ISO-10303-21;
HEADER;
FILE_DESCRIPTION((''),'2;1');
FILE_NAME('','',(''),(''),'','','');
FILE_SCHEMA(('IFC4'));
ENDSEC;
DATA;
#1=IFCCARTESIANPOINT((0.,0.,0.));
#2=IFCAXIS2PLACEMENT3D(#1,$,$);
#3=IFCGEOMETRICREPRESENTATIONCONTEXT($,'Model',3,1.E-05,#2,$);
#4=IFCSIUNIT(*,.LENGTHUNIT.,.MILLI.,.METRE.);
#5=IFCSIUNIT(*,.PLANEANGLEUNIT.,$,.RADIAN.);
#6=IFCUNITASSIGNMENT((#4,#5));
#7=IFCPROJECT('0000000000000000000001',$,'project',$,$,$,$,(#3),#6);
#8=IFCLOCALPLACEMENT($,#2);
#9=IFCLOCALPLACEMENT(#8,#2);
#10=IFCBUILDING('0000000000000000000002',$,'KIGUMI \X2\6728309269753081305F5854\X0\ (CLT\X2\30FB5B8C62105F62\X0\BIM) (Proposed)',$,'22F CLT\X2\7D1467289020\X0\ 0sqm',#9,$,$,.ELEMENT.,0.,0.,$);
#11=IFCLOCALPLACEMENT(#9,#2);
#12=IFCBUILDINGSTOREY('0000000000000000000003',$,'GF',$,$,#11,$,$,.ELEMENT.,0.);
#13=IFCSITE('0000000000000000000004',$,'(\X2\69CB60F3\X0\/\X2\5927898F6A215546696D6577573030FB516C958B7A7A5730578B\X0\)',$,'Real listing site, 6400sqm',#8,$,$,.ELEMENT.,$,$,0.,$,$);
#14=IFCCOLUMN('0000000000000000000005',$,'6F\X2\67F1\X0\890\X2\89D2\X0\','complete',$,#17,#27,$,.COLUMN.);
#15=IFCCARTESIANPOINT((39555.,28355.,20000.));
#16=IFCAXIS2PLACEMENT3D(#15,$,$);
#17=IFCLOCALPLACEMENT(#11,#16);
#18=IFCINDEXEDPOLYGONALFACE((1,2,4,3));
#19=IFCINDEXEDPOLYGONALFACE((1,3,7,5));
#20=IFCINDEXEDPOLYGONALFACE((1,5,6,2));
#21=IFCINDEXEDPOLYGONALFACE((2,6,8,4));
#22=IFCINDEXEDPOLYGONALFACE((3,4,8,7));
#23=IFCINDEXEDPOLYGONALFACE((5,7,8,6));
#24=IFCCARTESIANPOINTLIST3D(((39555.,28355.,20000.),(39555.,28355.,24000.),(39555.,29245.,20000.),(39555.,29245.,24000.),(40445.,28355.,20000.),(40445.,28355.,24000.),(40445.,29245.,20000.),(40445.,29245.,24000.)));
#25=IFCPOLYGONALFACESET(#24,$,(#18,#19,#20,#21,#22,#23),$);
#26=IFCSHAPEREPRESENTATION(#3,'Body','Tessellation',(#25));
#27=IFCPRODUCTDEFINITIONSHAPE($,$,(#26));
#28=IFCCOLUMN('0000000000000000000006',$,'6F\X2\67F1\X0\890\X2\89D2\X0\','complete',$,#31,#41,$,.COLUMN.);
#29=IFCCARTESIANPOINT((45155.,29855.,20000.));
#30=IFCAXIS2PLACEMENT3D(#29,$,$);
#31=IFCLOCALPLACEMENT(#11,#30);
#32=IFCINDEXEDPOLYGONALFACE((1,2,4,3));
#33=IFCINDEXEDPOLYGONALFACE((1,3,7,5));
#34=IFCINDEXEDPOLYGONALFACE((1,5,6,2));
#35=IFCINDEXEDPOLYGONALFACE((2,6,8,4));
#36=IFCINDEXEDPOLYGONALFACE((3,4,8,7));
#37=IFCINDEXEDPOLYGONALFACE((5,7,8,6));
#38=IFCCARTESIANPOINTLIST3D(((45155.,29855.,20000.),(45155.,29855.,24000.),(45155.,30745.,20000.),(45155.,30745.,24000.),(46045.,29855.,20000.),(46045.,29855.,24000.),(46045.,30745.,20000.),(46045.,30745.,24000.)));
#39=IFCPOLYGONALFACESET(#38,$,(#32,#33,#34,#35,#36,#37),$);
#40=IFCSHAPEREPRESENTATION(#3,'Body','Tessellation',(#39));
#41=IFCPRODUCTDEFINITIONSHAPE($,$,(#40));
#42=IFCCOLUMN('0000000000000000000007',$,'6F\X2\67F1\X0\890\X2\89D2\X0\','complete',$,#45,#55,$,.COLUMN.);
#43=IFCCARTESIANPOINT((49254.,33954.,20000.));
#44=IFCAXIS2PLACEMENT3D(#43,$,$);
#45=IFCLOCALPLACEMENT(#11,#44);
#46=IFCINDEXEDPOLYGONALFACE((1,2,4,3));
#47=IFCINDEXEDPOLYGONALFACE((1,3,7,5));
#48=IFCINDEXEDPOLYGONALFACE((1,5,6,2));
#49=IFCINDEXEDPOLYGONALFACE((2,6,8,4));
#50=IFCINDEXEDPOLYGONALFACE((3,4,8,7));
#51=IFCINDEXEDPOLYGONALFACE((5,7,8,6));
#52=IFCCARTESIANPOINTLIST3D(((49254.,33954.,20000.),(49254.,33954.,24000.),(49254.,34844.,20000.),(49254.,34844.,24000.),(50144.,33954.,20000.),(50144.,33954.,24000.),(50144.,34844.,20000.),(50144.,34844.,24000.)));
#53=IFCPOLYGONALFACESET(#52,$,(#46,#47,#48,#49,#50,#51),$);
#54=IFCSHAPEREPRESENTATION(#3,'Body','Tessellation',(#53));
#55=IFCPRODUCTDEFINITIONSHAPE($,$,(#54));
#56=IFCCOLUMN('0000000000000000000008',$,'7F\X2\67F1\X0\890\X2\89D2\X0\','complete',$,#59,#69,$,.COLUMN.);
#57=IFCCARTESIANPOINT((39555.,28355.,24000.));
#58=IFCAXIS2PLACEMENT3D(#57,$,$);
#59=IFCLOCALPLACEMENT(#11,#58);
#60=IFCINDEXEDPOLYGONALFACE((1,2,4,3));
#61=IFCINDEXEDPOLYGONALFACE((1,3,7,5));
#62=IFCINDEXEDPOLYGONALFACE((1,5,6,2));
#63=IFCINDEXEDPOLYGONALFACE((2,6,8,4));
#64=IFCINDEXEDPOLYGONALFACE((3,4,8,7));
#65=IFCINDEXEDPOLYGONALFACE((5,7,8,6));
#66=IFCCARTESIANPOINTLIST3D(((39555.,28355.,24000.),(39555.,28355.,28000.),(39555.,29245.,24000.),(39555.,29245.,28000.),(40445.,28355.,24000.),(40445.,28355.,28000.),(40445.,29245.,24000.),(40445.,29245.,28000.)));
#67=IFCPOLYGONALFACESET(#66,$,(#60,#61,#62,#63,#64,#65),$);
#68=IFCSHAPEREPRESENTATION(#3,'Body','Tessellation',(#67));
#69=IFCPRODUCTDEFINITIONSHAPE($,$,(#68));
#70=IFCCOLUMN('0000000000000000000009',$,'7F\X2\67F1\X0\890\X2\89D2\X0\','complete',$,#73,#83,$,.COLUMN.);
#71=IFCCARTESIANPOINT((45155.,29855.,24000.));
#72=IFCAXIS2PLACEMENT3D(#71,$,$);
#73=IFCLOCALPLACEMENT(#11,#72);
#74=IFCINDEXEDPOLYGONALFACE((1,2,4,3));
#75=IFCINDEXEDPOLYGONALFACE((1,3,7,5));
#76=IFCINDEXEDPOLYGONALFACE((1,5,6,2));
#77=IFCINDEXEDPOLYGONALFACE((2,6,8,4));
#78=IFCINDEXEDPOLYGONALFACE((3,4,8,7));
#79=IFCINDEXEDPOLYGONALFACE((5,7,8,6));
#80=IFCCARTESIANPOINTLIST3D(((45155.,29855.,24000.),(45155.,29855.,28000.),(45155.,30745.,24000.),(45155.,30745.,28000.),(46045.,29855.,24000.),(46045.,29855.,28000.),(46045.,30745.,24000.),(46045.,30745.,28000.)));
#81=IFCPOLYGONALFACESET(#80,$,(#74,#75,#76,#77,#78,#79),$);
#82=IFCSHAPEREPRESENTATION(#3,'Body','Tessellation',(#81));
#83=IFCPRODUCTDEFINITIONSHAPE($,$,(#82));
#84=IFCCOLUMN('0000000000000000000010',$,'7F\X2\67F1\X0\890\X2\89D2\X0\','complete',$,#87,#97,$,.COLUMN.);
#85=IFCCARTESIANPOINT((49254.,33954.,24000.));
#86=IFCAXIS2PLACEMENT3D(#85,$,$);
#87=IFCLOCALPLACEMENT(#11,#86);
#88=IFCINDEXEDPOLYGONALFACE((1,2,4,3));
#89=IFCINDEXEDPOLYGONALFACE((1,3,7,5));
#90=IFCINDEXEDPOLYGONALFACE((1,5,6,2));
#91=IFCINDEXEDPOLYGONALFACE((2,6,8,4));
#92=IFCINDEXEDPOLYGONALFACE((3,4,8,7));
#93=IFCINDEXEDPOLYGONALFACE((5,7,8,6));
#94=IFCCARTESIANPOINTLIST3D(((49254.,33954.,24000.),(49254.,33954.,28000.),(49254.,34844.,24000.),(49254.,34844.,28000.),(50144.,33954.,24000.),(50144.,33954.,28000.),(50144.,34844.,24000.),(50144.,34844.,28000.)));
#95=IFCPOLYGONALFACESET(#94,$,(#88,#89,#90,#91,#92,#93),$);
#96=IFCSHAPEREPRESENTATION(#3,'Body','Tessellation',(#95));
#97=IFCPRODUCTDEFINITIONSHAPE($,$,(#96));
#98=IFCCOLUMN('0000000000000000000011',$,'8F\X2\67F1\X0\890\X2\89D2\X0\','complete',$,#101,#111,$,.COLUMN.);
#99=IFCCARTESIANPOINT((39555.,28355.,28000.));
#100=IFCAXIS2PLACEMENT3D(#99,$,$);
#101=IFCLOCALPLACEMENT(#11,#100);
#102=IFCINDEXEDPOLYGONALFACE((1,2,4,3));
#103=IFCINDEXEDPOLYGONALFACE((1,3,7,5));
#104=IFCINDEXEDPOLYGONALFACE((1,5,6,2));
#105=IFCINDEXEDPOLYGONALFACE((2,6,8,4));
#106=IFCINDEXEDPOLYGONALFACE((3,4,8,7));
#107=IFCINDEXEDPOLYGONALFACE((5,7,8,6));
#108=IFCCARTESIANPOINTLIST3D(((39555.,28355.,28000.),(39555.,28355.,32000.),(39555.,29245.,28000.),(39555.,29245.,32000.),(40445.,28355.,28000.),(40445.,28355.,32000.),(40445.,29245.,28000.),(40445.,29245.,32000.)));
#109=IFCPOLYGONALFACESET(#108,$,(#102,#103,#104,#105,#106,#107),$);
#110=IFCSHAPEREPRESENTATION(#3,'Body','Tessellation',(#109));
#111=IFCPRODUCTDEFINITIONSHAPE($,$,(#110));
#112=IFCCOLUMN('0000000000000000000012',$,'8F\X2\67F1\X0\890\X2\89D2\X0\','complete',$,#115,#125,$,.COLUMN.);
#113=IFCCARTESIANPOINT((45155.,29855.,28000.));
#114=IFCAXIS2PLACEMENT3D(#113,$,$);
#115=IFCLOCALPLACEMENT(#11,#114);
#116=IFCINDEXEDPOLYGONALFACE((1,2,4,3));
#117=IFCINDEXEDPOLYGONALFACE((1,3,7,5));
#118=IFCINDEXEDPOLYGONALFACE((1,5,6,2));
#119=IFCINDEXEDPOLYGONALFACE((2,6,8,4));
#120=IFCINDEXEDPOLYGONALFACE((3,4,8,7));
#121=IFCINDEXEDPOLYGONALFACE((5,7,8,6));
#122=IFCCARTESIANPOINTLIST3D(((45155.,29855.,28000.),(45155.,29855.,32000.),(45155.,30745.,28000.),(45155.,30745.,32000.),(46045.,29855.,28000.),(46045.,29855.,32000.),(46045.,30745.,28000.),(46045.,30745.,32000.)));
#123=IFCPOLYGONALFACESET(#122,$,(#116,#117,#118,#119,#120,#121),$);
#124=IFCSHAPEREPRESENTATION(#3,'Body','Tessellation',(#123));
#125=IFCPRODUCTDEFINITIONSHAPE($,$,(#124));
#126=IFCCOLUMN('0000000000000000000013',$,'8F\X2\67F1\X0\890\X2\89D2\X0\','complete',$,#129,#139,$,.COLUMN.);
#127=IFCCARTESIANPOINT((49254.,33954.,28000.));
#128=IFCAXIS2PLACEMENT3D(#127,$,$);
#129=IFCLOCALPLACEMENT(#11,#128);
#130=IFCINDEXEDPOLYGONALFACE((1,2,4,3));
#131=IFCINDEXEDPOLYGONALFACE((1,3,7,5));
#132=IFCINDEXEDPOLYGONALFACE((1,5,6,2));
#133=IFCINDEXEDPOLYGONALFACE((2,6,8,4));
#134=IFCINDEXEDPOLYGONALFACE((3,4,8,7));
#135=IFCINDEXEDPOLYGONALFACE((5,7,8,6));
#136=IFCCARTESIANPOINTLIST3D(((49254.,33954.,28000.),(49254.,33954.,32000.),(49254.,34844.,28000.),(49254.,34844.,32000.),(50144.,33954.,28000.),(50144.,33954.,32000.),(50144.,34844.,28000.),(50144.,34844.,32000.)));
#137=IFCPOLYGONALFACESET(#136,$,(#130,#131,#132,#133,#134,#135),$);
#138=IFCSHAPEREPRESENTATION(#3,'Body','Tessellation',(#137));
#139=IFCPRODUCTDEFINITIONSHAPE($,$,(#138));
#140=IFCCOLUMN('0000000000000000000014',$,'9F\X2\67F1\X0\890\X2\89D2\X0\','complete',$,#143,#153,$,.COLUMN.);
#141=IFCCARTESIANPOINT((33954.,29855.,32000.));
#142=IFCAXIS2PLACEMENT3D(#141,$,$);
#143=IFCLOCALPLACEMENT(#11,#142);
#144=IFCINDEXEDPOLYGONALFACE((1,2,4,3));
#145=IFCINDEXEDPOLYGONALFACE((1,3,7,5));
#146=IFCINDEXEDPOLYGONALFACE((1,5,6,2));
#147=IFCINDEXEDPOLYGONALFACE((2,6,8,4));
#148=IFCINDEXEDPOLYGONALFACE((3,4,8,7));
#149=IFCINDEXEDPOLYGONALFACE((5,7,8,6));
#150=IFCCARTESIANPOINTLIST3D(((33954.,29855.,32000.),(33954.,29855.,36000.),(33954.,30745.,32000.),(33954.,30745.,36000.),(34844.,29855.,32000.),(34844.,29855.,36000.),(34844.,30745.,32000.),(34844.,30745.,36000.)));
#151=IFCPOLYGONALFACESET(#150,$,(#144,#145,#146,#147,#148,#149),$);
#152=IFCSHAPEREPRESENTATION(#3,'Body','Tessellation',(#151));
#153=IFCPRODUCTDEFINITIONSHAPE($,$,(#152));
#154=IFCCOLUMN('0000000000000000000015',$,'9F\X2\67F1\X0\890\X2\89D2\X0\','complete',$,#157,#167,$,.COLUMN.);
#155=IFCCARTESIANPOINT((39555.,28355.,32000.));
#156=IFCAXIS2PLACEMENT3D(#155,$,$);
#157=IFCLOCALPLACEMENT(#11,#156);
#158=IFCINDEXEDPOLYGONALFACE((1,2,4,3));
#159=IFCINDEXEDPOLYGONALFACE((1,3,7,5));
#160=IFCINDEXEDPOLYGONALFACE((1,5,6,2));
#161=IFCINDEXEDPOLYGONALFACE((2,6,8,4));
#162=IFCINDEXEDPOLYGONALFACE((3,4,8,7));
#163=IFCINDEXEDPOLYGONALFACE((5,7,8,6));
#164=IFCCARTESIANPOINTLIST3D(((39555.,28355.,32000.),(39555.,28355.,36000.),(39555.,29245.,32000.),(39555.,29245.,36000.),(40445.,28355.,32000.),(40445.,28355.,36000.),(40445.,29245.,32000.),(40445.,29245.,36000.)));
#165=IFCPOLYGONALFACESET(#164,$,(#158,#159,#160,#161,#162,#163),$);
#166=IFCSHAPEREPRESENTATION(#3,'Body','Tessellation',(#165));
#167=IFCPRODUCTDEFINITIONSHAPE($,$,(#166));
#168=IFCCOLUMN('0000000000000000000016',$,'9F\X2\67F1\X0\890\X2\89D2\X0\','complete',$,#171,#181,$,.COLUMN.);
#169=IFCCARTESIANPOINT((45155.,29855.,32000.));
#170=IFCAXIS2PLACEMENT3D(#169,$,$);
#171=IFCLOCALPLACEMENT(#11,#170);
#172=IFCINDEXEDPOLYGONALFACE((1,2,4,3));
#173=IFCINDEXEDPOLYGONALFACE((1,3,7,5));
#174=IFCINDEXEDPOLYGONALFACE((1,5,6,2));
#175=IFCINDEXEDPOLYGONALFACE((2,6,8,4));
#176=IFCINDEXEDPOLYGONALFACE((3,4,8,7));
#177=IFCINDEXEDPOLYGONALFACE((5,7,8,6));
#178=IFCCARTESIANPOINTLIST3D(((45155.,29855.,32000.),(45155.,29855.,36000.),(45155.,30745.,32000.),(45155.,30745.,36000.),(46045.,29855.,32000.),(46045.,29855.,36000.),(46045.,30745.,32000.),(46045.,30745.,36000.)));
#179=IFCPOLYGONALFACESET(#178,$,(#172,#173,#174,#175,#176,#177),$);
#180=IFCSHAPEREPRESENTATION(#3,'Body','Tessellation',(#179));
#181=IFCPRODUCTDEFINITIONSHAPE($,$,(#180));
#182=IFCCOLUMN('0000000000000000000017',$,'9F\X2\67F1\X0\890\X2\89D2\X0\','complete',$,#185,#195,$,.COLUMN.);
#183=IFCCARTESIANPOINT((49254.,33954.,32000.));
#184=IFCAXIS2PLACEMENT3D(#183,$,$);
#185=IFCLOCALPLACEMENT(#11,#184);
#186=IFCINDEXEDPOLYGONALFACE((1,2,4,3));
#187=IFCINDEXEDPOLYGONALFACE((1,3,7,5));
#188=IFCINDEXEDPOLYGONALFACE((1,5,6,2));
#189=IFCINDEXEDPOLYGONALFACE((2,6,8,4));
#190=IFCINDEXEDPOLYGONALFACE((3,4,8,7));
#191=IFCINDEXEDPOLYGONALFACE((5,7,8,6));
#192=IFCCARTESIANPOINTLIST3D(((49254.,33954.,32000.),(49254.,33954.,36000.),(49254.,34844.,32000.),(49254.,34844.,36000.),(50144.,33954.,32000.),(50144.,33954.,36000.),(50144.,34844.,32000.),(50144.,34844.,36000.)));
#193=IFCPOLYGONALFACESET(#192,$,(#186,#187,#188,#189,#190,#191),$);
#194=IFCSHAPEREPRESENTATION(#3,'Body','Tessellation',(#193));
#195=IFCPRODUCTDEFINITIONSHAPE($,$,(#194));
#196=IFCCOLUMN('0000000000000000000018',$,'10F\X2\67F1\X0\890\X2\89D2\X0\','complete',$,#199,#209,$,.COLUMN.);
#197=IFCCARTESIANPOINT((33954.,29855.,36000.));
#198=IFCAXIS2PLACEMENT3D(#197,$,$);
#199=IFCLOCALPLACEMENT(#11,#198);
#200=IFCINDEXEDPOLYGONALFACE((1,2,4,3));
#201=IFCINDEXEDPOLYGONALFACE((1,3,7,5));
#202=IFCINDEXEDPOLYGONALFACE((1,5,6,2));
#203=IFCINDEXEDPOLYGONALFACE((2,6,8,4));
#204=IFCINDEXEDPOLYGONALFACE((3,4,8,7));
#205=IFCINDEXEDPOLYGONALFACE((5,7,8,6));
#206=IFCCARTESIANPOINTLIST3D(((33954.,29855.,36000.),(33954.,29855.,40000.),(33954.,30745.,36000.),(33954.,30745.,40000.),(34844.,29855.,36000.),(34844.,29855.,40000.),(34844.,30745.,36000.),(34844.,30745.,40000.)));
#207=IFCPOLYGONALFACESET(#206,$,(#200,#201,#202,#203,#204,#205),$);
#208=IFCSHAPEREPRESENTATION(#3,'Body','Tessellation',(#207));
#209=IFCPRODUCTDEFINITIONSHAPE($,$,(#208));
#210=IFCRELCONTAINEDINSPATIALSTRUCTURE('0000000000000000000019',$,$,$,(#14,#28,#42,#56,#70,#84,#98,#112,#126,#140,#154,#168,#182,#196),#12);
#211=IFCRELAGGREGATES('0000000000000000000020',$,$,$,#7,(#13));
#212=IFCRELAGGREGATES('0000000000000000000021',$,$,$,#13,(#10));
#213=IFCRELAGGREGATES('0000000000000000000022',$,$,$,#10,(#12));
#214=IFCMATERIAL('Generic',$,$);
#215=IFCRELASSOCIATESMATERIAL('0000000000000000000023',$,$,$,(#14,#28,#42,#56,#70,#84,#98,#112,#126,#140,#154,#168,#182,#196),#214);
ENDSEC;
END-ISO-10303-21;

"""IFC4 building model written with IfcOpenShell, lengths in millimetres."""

from ifc_helpers import new_model, si_unit, frame, frame_2d, origin, place, context, project, spatial, rectangle, extrude, material, element, save


model = new_model("IFC4")

# Units and contexts
model_context = context("Model", 3, precision=1e-05, world=origin())
ifc_project = project(units=[si_unit("LENGTHUNIT", "METRE", prefix="MILLI"), si_unit("PLANEANGLEUNIT", "RADIAN")], contexts=[model_context])

# Site, building, storey
site_placement = place(None, origin())
site = spatial("IfcSite", under=ifc_project, at=site_placement, Name="(構想/大規模商業敷地・公開空地型)", ObjectType="Real listing site, 6400sqm", CompositionType="ELEMENT", RefElevation=0.0)
building_placement = place(site_placement, origin())
building = spatial("IfcBuilding", under=site, at=building_placement, Name="KIGUMI 木を極めた塔 (CLT・完成形BIM) (Proposed)", ObjectType="22F CLT純木造 0sqm", CompositionType="ELEMENT", ElevationOfRefHeight=0.0, ElevationOfTerrain=0.0)
storey_placement = place(building_placement, origin())
storey = spatial("IfcBuildingStorey", under=building, at=storey_placement, Name="GF", CompositionType="ELEMENT", Elevation=0.0)

# Columns
ifc_material = material(Name="Generic")
column_1_placement = place(storey_placement, frame((39555.0, 28355.0, 20000.0)))
element("IfcColumn", 1, at=column_1_placement, inside=storey, material=ifc_material, Name="6F柱890角", Description="complete", PredefinedType="COLUMN", context=model_context, shape_type="SweptSolid", body=[
    extrude(rectangle(XDim=890.0, YDim=890.0, at=frame_2d((445.0, 445.0))), frame((39555.0, 28355.0, 20000.0)), (0.0, 0.0, 1.0), 4000.0),
])
column_2_placement = place(storey_placement, frame((45155.0, 29855.0, 20000.0)))
element("IfcColumn", 2, at=column_2_placement, inside=storey, material=ifc_material, Name="6F柱890角", Description="complete", PredefinedType="COLUMN", context=model_context, shape_type="SweptSolid", body=[
    extrude(rectangle(XDim=890.0, YDim=890.0, at=frame_2d((445.0, 445.0))), frame((45155.0, 29855.0, 20000.0)), (0.0, 0.0, 1.0), 4000.0),
])
column_3_placement = place(storey_placement, frame((49254.0, 33954.0, 20000.0)))
element("IfcColumn", 3, at=column_3_placement, inside=storey, material=ifc_material, Name="6F柱890角", Description="complete", PredefinedType="COLUMN", context=model_context, shape_type="SweptSolid", body=[
    extrude(rectangle(XDim=890.0, YDim=890.0, at=frame_2d((445.0, 445.0))), frame((49254.0, 33954.0, 20000.0)), (0.0, 0.0, 1.0), 4000.0),
])
column_4_placement = place(storey_placement, frame((39555.0, 28355.0, 24000.0)))
element("IfcColumn", 4, at=column_4_placement, inside=storey, material=ifc_material, Name="7F柱890角", Description="complete", PredefinedType="COLUMN", context=model_context, shape_type="SweptSolid", body=[
    extrude(rectangle(XDim=890.0, YDim=890.0, at=frame_2d((445.0, 445.0))), frame((39555.0, 28355.0, 24000.0)), (0.0, 0.0, 1.0), 4000.0),
])
column_5_placement = place(storey_placement, frame((45155.0, 29855.0, 24000.0)))
element("IfcColumn", 5, at=column_5_placement, inside=storey, material=ifc_material, Name="7F柱890角", Description="complete", PredefinedType="COLUMN", context=model_context, shape_type="SweptSolid", body=[
    extrude(rectangle(XDim=890.0, YDim=890.0, at=frame_2d((445.0, 445.0))), frame((45155.0, 29855.0, 24000.0)), (0.0, 0.0, 1.0), 4000.0),
])
column_6_placement = place(storey_placement, frame((49254.0, 33954.0, 24000.0)))
element("IfcColumn", 6, at=column_6_placement, inside=storey, material=ifc_material, Name="7F柱890角", Description="complete", PredefinedType="COLUMN", context=model_context, shape_type="SweptSolid", body=[
    extrude(rectangle(XDim=890.0, YDim=890.0, at=frame_2d((445.0, 445.0))), frame((49254.0, 33954.0, 24000.0)), (0.0, 0.0, 1.0), 4000.0),
])
column_7_placement = place(storey_placement, frame((39555.0, 28355.0, 28000.0)))
element("IfcColumn", 7, at=column_7_placement, inside=storey, material=ifc_material, Name="8F柱890角", Description="complete", PredefinedType="COLUMN", context=model_context, shape_type="SweptSolid", body=[
    extrude(rectangle(XDim=890.0, YDim=890.0, at=frame_2d((445.0, 445.0))), frame((39555.0, 28355.0, 28000.0)), (0.0, 0.0, 1.0), 4000.0),
])
column_8_placement = place(storey_placement, frame((45155.0, 29855.0, 28000.0)))
element("IfcColumn", 8, at=column_8_placement, inside=storey, material=ifc_material, Name="8F柱890角", Description="complete", PredefinedType="COLUMN", context=model_context, shape_type="SweptSolid", body=[
    extrude(rectangle(XDim=890.0, YDim=890.0, at=frame_2d((445.0, 445.0))), frame((45155.0, 29855.0, 28000.0)), (0.0, 0.0, 1.0), 4000.0),
])
column_9_placement = place(storey_placement, frame((49254.0, 33954.0, 28000.0)))
element("IfcColumn", 9, at=column_9_placement, inside=storey, material=ifc_material, Name="8F柱890角", Description="complete", PredefinedType="COLUMN", context=model_context, shape_type="SweptSolid", body=[
    extrude(rectangle(XDim=890.0, YDim=890.0, at=frame_2d((445.0, 445.0))), frame((49254.0, 33954.0, 28000.0)), (0.0, 0.0, 1.0), 4000.0),
])
column_10_placement = place(storey_placement, frame((33954.0, 29855.0, 32000.0)))
element("IfcColumn", 10, at=column_10_placement, inside=storey, material=ifc_material, Name="9F柱890角", Description="complete", PredefinedType="COLUMN", context=model_context, shape_type="SweptSolid", body=[
    extrude(rectangle(XDim=890.0, YDim=890.0, at=frame_2d((445.0, 445.0))), frame((33954.0, 29855.0, 32000.0)), (0.0, 0.0, 1.0), 4000.0),
])
column_11_placement = place(storey_placement, frame((39555.0, 28355.0, 32000.0)))
element("IfcColumn", 11, at=column_11_placement, inside=storey, material=ifc_material, Name="9F柱890角", Description="complete", PredefinedType="COLUMN", context=model_context, shape_type="SweptSolid", body=[
    extrude(rectangle(XDim=890.0, YDim=890.0, at=frame_2d((445.0, 445.0))), frame((39555.0, 28355.0, 32000.0)), (0.0, 0.0, 1.0), 4000.0),
])
column_12_placement = place(storey_placement, frame((45155.0, 29855.0, 32000.0)))
element("IfcColumn", 12, at=column_12_placement, inside=storey, material=ifc_material, Name="9F柱890角", Description="complete", PredefinedType="COLUMN", context=model_context, shape_type="SweptSolid", body=[
    extrude(rectangle(XDim=890.0, YDim=890.0, at=frame_2d((445.0, 445.0))), frame((45155.0, 29855.0, 32000.0)), (0.0, 0.0, 1.0), 4000.0),
])
column_13_placement = place(storey_placement, frame((49254.0, 33954.0, 32000.0)))
element("IfcColumn", 13, at=column_13_placement, inside=storey, material=ifc_material, Name="9F柱890角", Description="complete", PredefinedType="COLUMN", context=model_context, shape_type="SweptSolid", body=[
    extrude(rectangle(XDim=890.0, YDim=890.0, at=frame_2d((445.0, 445.0))), frame((49254.0, 33954.0, 32000.0)), (0.0, 0.0, 1.0), 4000.0),
])
column_14_placement = place(storey_placement, frame((33954.0, 29855.0, 36000.0)))
element("IfcColumn", 14, at=column_14_placement, inside=storey, material=ifc_material, Name="10F柱890角", Description="complete", PredefinedType="COLUMN", context=model_context, shape_type="SweptSolid", body=[
    extrude(rectangle(XDim=890.0, YDim=890.0, at=frame_2d((445.0, 445.0))), frame((33954.0, 29855.0, 36000.0)), (0.0, 0.0, 1.0), 4000.0),
])

save(model, "model.ifc")
